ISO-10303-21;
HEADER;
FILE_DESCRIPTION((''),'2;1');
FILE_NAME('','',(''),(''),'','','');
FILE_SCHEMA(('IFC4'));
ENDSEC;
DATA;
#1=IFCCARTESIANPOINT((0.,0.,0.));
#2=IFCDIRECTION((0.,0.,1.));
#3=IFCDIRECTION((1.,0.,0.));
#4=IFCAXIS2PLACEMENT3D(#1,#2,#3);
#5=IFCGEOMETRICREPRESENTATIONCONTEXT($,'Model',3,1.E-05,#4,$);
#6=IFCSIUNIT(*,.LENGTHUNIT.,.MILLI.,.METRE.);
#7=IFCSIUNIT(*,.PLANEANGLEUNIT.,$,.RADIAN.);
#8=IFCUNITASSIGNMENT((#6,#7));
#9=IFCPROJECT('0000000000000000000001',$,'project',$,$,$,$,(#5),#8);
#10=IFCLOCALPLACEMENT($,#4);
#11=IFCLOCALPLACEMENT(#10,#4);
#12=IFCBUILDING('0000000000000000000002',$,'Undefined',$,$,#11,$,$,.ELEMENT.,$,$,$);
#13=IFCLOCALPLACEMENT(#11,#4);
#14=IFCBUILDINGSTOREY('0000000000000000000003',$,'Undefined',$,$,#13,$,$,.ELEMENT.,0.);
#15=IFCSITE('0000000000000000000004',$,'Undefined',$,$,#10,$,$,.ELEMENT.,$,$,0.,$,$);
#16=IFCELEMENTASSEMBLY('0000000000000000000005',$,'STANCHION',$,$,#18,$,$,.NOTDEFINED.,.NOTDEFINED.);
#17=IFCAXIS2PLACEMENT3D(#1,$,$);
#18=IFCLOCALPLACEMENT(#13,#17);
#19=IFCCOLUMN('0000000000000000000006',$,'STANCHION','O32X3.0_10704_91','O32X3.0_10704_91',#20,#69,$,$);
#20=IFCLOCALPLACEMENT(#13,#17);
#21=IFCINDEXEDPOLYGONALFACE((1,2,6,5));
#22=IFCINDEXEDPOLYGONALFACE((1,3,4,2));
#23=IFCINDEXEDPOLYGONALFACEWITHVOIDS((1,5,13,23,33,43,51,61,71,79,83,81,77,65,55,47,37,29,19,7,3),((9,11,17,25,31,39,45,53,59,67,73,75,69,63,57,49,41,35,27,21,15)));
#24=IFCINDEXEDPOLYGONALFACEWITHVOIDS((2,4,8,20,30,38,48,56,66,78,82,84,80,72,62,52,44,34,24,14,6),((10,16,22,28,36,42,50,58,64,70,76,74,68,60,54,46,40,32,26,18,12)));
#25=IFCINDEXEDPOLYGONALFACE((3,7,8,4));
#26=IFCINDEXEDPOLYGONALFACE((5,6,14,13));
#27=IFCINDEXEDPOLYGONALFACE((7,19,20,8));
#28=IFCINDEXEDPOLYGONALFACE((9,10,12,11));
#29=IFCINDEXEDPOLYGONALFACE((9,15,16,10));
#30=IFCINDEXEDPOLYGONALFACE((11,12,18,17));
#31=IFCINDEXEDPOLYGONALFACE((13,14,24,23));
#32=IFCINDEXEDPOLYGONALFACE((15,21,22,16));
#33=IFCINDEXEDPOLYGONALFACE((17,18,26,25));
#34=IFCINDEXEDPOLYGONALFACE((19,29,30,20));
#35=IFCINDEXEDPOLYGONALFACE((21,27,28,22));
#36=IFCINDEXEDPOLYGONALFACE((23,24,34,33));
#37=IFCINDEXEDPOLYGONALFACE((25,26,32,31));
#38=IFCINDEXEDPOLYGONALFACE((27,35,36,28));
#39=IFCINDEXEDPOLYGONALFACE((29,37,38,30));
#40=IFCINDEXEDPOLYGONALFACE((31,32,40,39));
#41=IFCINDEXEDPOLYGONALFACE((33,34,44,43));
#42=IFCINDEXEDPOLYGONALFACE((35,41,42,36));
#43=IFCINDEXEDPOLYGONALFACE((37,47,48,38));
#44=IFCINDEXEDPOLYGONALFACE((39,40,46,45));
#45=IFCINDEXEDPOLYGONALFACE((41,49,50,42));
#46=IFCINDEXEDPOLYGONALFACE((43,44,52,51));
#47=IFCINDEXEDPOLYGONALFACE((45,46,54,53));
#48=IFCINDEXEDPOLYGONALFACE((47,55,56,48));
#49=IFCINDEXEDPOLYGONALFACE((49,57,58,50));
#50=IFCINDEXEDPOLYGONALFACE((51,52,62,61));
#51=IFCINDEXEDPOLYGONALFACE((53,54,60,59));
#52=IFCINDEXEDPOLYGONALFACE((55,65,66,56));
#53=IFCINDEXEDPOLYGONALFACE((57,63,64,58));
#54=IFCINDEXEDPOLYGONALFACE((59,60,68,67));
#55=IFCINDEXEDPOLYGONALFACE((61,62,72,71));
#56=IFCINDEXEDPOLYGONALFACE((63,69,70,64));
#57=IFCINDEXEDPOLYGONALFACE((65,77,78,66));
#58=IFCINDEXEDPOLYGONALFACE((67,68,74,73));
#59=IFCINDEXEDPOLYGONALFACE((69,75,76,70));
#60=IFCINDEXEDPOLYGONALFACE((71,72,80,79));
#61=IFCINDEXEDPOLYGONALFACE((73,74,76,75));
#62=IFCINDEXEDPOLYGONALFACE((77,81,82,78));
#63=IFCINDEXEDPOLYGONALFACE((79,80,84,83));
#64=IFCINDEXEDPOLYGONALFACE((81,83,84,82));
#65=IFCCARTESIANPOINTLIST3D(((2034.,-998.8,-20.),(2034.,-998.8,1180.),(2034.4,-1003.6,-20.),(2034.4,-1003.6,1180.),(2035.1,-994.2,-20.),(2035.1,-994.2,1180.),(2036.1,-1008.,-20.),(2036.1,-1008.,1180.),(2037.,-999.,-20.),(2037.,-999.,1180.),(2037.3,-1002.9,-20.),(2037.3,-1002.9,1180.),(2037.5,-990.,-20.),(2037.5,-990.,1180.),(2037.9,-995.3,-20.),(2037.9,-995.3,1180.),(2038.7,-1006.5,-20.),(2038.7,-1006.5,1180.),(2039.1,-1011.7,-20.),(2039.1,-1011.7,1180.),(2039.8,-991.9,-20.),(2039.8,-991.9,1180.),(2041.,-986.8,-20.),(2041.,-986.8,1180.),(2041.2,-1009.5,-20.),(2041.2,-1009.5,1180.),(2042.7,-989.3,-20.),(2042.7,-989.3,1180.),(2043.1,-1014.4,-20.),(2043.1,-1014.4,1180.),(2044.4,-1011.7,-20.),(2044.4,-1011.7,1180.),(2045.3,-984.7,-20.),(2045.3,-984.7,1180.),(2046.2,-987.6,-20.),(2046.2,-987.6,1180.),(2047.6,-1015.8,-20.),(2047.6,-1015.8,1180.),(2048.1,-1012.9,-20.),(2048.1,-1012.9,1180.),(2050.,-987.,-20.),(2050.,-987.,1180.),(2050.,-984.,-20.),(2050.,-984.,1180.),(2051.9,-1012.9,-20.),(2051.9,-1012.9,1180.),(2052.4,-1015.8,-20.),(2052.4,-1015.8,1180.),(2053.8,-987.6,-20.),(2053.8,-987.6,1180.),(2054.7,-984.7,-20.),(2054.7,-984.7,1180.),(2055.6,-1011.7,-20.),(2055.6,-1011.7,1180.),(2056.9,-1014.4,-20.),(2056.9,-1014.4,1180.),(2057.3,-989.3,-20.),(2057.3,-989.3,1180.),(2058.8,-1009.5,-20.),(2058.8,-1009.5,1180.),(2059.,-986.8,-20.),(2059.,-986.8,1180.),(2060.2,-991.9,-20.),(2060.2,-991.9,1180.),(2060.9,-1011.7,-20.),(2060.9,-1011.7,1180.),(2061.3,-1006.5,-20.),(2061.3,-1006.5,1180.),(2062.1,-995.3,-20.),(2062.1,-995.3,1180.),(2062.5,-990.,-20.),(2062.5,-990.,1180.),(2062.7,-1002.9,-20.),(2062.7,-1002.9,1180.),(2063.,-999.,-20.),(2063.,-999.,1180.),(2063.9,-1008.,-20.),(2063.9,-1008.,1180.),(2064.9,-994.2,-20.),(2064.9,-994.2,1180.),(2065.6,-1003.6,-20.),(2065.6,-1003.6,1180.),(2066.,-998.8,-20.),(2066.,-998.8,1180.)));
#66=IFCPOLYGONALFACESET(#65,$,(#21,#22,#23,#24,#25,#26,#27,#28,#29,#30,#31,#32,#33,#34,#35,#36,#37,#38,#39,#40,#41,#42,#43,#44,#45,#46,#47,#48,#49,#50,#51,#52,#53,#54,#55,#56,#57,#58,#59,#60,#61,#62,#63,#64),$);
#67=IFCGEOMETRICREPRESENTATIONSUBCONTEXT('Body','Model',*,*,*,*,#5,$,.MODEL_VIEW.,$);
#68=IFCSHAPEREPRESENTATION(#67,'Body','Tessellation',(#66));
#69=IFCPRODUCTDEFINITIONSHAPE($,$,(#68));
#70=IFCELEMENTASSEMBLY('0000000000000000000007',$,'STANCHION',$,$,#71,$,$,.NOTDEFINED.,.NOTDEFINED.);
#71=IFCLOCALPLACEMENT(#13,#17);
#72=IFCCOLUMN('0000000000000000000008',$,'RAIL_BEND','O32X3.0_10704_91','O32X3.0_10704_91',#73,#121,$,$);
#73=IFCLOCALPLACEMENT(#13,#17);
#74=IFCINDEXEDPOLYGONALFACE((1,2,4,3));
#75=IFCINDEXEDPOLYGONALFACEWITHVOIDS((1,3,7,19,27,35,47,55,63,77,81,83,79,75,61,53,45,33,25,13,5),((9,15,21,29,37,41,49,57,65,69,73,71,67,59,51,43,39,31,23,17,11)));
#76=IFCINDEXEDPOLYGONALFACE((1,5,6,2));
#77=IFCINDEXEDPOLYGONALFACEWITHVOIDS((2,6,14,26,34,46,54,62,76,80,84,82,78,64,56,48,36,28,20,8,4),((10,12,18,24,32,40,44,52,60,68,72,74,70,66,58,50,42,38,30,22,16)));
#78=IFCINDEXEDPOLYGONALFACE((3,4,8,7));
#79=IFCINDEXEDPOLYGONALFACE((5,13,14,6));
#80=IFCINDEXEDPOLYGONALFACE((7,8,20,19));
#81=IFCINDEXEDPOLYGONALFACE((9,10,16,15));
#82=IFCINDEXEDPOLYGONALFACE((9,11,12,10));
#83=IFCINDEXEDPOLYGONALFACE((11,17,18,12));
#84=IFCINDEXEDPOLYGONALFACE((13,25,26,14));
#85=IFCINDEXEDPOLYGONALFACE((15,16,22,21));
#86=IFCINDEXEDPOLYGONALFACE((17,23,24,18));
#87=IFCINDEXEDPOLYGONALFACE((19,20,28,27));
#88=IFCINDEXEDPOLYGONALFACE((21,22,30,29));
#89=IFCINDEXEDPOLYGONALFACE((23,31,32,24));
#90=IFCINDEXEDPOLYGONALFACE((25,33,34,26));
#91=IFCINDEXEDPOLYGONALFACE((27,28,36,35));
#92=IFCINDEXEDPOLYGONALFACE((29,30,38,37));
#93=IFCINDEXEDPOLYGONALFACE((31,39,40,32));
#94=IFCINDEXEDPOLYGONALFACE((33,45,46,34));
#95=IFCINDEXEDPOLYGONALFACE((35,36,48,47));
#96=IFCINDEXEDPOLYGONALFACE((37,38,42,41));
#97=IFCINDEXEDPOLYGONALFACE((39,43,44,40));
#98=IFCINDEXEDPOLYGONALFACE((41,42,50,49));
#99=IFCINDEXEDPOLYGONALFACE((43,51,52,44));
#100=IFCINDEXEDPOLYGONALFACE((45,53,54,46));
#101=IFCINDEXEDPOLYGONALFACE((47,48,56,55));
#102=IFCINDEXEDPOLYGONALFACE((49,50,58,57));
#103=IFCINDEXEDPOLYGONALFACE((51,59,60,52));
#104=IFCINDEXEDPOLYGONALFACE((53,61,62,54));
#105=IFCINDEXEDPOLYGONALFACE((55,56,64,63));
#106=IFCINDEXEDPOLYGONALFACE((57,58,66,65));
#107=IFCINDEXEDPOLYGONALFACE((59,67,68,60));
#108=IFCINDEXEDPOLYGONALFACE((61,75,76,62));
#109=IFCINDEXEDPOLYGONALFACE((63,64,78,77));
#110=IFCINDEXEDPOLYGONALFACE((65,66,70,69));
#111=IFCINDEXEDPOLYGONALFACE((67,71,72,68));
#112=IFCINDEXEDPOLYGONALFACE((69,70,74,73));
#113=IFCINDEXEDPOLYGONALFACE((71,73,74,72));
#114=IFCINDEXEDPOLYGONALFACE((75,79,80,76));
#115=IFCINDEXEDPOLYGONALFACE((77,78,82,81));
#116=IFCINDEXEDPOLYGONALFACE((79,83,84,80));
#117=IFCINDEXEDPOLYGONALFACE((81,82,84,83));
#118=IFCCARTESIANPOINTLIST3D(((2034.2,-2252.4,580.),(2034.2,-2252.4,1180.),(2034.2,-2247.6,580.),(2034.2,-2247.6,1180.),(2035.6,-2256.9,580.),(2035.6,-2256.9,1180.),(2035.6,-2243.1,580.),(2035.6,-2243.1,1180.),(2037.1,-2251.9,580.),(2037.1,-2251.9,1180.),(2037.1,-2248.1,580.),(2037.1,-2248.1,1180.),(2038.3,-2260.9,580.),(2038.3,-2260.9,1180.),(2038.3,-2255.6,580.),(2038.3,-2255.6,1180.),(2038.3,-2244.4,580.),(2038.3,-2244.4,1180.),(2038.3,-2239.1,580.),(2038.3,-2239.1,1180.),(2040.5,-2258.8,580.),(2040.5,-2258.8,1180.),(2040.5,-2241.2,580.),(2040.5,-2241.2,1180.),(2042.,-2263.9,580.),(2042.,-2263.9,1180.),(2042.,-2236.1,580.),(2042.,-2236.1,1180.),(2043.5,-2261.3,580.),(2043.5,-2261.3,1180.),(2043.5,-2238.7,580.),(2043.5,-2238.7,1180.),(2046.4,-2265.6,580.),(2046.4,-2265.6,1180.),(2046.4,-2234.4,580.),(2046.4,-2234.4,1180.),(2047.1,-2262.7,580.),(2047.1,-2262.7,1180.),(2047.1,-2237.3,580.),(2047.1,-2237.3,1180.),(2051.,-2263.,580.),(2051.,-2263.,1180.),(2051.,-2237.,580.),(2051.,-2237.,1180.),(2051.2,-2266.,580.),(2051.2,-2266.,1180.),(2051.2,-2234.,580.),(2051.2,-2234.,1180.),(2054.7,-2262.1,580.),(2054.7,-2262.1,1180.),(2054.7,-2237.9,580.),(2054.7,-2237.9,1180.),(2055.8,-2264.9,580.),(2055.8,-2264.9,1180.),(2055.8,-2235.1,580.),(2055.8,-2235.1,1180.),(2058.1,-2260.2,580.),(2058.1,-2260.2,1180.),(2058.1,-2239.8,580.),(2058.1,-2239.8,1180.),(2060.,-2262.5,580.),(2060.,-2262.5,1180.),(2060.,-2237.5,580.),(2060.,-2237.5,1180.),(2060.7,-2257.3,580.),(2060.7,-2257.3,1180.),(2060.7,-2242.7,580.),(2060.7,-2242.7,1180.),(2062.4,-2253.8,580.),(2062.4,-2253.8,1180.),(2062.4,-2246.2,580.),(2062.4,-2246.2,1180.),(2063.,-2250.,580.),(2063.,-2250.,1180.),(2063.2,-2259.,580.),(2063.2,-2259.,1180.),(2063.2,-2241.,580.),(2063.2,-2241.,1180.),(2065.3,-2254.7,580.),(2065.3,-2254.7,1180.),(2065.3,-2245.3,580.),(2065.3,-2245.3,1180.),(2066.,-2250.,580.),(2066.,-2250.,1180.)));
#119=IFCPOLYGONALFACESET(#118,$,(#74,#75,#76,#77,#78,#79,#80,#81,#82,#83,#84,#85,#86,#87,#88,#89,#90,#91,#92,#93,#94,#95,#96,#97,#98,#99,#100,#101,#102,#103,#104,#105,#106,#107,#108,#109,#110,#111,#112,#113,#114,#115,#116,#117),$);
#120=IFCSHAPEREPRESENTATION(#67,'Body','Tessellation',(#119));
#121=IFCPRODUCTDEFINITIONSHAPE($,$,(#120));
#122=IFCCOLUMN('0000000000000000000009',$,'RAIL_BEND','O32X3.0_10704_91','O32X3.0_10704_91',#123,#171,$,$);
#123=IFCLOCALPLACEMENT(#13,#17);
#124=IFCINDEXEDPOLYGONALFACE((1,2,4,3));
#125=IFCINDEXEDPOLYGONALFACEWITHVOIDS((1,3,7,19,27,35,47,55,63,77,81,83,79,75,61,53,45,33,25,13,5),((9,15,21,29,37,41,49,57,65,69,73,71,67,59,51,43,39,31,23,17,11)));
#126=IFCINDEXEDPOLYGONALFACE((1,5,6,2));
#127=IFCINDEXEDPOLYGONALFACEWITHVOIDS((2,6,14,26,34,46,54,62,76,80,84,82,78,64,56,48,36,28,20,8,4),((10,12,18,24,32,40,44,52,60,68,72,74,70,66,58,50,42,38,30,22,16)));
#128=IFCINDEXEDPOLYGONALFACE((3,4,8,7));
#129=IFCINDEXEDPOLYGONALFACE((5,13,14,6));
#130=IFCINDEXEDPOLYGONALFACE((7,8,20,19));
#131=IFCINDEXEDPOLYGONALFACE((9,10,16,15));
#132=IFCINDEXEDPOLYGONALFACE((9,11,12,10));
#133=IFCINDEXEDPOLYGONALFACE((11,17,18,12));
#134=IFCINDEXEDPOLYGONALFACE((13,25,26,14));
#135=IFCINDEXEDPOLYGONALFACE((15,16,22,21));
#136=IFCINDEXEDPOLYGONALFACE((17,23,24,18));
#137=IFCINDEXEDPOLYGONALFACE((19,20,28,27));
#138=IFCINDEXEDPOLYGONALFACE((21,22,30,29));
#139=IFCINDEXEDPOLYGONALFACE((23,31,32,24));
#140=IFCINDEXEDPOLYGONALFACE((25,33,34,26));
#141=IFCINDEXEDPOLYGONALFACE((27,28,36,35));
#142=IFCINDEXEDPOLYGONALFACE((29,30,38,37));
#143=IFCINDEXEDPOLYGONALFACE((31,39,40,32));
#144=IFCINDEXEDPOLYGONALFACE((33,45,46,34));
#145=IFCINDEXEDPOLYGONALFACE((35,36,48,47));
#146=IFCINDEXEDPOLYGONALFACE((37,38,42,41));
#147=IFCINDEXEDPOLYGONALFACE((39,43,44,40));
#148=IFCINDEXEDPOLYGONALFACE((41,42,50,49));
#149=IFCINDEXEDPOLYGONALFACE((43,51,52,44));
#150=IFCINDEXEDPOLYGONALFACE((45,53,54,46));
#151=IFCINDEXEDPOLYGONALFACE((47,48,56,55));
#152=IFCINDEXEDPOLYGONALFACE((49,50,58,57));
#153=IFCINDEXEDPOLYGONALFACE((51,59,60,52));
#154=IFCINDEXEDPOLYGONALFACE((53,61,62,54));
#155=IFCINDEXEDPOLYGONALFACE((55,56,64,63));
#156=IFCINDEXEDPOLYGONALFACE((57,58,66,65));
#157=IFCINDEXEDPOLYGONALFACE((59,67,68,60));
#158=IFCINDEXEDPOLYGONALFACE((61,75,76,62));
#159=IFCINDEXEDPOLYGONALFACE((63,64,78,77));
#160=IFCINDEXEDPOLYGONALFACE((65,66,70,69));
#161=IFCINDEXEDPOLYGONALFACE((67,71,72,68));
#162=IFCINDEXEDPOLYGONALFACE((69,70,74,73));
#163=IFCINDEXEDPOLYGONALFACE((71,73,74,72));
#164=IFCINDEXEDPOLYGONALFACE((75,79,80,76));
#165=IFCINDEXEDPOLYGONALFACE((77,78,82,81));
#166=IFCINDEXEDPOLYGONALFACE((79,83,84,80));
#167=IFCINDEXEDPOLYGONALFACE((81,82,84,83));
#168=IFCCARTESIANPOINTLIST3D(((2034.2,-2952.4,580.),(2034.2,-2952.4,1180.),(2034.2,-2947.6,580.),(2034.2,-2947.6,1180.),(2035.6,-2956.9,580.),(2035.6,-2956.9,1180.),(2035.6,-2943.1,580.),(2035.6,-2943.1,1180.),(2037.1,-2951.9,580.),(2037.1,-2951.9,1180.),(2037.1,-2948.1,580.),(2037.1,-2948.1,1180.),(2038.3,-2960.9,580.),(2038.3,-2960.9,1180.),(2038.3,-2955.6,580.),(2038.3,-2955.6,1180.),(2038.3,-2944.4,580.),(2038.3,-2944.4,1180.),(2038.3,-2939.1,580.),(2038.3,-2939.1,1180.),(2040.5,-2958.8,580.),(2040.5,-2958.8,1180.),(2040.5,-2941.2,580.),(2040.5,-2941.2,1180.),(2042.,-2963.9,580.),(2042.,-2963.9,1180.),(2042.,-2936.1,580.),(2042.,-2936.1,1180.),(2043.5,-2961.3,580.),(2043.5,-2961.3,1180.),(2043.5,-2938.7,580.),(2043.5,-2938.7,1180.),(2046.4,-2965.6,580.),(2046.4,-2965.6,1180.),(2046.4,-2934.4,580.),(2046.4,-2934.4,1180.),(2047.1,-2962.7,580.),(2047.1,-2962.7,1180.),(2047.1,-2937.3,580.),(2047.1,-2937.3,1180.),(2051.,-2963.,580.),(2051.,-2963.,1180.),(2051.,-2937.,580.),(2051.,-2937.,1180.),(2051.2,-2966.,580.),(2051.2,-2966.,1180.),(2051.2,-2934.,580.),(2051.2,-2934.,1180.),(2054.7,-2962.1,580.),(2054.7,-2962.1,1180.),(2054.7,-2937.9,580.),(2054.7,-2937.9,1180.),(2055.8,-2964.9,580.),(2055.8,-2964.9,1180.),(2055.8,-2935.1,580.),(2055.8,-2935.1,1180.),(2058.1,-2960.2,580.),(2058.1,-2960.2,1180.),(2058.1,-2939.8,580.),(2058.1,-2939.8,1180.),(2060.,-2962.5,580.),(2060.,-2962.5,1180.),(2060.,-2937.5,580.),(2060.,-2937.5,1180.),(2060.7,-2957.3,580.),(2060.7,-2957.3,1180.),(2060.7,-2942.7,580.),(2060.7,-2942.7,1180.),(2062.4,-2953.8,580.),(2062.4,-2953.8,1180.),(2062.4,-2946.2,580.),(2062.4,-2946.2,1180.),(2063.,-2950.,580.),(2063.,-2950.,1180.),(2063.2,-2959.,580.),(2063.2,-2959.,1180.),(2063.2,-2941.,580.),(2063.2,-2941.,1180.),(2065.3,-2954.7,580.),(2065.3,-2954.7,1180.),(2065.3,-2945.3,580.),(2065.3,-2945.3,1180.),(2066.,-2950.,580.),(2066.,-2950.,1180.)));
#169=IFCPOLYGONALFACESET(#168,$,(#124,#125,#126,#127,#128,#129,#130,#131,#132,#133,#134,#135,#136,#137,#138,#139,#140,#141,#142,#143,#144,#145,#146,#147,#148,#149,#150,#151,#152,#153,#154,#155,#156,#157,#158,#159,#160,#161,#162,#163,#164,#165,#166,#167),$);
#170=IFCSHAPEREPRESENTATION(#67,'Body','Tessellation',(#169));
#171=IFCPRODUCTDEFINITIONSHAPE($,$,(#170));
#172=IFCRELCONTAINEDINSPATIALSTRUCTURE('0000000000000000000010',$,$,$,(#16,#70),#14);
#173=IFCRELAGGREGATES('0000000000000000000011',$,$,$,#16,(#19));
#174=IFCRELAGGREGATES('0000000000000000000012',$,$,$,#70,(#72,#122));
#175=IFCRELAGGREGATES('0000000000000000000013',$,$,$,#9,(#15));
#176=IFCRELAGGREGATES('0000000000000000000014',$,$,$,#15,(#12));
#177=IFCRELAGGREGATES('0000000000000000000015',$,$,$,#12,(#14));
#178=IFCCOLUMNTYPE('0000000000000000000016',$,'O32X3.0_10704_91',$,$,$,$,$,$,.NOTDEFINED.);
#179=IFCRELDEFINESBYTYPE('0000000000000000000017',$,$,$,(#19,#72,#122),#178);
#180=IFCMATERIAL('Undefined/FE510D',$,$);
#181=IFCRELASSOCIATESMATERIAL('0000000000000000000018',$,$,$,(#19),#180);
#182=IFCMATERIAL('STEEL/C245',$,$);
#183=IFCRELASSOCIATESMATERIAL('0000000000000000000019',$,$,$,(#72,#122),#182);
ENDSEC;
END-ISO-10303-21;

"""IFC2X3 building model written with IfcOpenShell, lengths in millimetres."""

from ifc_helpers import new_model, si_unit, frame, origin_with_axes, origin_2d_with_axis, place, context, subcontext, project, spatial, hollow_circle, extrude, material, type_object, element, aggregate, save


model = new_model("IFC2X3")

# Units and contexts
model_context = context("Model", 3, precision=1e-05, world=origin_with_axes())
body_context = subcontext(model_context, "Body", "Model", "MODEL_VIEW")
ifc_project = project(units=[si_unit("LENGTHUNIT", "METRE", prefix="MILLI"), si_unit("PLANEANGLEUNIT", "RADIAN")], contexts=[model_context])

# Site, building, storey
site_placement = place(None, origin_with_axes())
site = spatial("IfcSite", under=ifc_project, at=site_placement, Name="Undefined", CompositionType="ELEMENT", RefElevation=0.0)
building_placement = place(site_placement, origin_with_axes())
building = spatial("IfcBuilding", under=site, at=building_placement, Name="Undefined", CompositionType="ELEMENT")
storey_placement = place(building_placement, origin_with_axes())
storey = spatial("IfcBuildingStorey", under=building, at=storey_placement, Name="Undefined", CompositionType="ELEMENT", Elevation=0.0)

# Element assembly
assembly_1_placement = place(storey_placement, origin_with_axes())
assembly_1 = element("IfcElementAssembly", 1, at=assembly_1_placement, inside=storey, Name="STANCHION", AssemblyPlace="NOTDEFINED", PredefinedType="NOTDEFINED")
ifc_material_1 = material(Name="STEEL/C245")
column_type = type_object("IfcColumnType", Name="O32X3.0_10704_91", PredefinedType="NOTDEFINED")

# Shared definitions
ifc_material_2 = material(Name="Undefined/FE510D")

# Column
column_1_placement = place(assembly_1_placement, frame((2050.0, -1000.0, -20.0), z_axis=(0.0, 0.0, 1.0), x_axis=(1.0, 0.0, 0.0)))
column_1 = element("IfcColumn", 2, at=column_1_placement, type_object=column_type, material=ifc_material_2, Name="STANCHION", Description="O32X3.0_10704_91", ObjectType="O32X3.0_10704_91", context=body_context, shape_type="SweptSolid", body=[
    extrude(hollow_circle(Radius=16.0, WallThickness=3.0, at=origin_2d_with_axis()), frame((0.0, 0.0, 1200.0), z_axis=(0.0, 0.0, -1.0), x_axis=(0.0, 1.0, 0.0)), (0.0, 0.0, 1.0), 1200.0),
])

# Element assembly, columns
assembly_2_placement = place(storey_placement, origin_with_axes())
assembly_2 = element("IfcElementAssembly", 3, at=assembly_2_placement, inside=storey, Name="STANCHION", AssemblyPlace="NOTDEFINED", PredefinedType="NOTDEFINED")
column_2_placement = place(assembly_2_placement, frame((2050.0, -2250.0, 580.0), z_axis=(0.0, 0.0, 1.0), x_axis=(0.0, -1.0, 0.0)))
column_2 = element("IfcColumn", 4, at=column_2_placement, type_object=column_type, material=ifc_material_1, Name="RAIL_BEND", Description="O32X3.0_10704_91", ObjectType="O32X3.0_10704_91", context=body_context, shape_type="SweptSolid", body=[
    extrude(hollow_circle(Radius=16.0, WallThickness=3.0, at=origin_2d_with_axis()), frame((0.0, 0.0, 600.0), z_axis=(0.0, 0.0, -1.0), x_axis=(0.0, 1.0, 0.0)), (0.0, 0.0, 1.0), 600.0),
])
column_3_placement = place(assembly_2_placement, frame((2050.0, -2950.0, 580.0), z_axis=(0.0, 0.0, 1.0), x_axis=(0.0, -1.0, 0.0)))
column_3 = element("IfcColumn", 5, at=column_3_placement, type_object=column_type, material=ifc_material_1, Name="RAIL_BEND", Description="O32X3.0_10704_91", ObjectType="O32X3.0_10704_91", context=body_context, shape_type="SweptSolid", body=[
    extrude(hollow_circle(Radius=16.0, WallThickness=3.0, at=origin_2d_with_axis()), frame((0.0, 0.0, 600.0), z_axis=(0.0, 0.0, -1.0), x_axis=(0.0, 1.0, 0.0)), (0.0, 0.0, 1.0), 600.0),
])

aggregate(assembly_1, [column_1])
aggregate(assembly_2, [column_2, column_3])

save(model, "model.ifc")
